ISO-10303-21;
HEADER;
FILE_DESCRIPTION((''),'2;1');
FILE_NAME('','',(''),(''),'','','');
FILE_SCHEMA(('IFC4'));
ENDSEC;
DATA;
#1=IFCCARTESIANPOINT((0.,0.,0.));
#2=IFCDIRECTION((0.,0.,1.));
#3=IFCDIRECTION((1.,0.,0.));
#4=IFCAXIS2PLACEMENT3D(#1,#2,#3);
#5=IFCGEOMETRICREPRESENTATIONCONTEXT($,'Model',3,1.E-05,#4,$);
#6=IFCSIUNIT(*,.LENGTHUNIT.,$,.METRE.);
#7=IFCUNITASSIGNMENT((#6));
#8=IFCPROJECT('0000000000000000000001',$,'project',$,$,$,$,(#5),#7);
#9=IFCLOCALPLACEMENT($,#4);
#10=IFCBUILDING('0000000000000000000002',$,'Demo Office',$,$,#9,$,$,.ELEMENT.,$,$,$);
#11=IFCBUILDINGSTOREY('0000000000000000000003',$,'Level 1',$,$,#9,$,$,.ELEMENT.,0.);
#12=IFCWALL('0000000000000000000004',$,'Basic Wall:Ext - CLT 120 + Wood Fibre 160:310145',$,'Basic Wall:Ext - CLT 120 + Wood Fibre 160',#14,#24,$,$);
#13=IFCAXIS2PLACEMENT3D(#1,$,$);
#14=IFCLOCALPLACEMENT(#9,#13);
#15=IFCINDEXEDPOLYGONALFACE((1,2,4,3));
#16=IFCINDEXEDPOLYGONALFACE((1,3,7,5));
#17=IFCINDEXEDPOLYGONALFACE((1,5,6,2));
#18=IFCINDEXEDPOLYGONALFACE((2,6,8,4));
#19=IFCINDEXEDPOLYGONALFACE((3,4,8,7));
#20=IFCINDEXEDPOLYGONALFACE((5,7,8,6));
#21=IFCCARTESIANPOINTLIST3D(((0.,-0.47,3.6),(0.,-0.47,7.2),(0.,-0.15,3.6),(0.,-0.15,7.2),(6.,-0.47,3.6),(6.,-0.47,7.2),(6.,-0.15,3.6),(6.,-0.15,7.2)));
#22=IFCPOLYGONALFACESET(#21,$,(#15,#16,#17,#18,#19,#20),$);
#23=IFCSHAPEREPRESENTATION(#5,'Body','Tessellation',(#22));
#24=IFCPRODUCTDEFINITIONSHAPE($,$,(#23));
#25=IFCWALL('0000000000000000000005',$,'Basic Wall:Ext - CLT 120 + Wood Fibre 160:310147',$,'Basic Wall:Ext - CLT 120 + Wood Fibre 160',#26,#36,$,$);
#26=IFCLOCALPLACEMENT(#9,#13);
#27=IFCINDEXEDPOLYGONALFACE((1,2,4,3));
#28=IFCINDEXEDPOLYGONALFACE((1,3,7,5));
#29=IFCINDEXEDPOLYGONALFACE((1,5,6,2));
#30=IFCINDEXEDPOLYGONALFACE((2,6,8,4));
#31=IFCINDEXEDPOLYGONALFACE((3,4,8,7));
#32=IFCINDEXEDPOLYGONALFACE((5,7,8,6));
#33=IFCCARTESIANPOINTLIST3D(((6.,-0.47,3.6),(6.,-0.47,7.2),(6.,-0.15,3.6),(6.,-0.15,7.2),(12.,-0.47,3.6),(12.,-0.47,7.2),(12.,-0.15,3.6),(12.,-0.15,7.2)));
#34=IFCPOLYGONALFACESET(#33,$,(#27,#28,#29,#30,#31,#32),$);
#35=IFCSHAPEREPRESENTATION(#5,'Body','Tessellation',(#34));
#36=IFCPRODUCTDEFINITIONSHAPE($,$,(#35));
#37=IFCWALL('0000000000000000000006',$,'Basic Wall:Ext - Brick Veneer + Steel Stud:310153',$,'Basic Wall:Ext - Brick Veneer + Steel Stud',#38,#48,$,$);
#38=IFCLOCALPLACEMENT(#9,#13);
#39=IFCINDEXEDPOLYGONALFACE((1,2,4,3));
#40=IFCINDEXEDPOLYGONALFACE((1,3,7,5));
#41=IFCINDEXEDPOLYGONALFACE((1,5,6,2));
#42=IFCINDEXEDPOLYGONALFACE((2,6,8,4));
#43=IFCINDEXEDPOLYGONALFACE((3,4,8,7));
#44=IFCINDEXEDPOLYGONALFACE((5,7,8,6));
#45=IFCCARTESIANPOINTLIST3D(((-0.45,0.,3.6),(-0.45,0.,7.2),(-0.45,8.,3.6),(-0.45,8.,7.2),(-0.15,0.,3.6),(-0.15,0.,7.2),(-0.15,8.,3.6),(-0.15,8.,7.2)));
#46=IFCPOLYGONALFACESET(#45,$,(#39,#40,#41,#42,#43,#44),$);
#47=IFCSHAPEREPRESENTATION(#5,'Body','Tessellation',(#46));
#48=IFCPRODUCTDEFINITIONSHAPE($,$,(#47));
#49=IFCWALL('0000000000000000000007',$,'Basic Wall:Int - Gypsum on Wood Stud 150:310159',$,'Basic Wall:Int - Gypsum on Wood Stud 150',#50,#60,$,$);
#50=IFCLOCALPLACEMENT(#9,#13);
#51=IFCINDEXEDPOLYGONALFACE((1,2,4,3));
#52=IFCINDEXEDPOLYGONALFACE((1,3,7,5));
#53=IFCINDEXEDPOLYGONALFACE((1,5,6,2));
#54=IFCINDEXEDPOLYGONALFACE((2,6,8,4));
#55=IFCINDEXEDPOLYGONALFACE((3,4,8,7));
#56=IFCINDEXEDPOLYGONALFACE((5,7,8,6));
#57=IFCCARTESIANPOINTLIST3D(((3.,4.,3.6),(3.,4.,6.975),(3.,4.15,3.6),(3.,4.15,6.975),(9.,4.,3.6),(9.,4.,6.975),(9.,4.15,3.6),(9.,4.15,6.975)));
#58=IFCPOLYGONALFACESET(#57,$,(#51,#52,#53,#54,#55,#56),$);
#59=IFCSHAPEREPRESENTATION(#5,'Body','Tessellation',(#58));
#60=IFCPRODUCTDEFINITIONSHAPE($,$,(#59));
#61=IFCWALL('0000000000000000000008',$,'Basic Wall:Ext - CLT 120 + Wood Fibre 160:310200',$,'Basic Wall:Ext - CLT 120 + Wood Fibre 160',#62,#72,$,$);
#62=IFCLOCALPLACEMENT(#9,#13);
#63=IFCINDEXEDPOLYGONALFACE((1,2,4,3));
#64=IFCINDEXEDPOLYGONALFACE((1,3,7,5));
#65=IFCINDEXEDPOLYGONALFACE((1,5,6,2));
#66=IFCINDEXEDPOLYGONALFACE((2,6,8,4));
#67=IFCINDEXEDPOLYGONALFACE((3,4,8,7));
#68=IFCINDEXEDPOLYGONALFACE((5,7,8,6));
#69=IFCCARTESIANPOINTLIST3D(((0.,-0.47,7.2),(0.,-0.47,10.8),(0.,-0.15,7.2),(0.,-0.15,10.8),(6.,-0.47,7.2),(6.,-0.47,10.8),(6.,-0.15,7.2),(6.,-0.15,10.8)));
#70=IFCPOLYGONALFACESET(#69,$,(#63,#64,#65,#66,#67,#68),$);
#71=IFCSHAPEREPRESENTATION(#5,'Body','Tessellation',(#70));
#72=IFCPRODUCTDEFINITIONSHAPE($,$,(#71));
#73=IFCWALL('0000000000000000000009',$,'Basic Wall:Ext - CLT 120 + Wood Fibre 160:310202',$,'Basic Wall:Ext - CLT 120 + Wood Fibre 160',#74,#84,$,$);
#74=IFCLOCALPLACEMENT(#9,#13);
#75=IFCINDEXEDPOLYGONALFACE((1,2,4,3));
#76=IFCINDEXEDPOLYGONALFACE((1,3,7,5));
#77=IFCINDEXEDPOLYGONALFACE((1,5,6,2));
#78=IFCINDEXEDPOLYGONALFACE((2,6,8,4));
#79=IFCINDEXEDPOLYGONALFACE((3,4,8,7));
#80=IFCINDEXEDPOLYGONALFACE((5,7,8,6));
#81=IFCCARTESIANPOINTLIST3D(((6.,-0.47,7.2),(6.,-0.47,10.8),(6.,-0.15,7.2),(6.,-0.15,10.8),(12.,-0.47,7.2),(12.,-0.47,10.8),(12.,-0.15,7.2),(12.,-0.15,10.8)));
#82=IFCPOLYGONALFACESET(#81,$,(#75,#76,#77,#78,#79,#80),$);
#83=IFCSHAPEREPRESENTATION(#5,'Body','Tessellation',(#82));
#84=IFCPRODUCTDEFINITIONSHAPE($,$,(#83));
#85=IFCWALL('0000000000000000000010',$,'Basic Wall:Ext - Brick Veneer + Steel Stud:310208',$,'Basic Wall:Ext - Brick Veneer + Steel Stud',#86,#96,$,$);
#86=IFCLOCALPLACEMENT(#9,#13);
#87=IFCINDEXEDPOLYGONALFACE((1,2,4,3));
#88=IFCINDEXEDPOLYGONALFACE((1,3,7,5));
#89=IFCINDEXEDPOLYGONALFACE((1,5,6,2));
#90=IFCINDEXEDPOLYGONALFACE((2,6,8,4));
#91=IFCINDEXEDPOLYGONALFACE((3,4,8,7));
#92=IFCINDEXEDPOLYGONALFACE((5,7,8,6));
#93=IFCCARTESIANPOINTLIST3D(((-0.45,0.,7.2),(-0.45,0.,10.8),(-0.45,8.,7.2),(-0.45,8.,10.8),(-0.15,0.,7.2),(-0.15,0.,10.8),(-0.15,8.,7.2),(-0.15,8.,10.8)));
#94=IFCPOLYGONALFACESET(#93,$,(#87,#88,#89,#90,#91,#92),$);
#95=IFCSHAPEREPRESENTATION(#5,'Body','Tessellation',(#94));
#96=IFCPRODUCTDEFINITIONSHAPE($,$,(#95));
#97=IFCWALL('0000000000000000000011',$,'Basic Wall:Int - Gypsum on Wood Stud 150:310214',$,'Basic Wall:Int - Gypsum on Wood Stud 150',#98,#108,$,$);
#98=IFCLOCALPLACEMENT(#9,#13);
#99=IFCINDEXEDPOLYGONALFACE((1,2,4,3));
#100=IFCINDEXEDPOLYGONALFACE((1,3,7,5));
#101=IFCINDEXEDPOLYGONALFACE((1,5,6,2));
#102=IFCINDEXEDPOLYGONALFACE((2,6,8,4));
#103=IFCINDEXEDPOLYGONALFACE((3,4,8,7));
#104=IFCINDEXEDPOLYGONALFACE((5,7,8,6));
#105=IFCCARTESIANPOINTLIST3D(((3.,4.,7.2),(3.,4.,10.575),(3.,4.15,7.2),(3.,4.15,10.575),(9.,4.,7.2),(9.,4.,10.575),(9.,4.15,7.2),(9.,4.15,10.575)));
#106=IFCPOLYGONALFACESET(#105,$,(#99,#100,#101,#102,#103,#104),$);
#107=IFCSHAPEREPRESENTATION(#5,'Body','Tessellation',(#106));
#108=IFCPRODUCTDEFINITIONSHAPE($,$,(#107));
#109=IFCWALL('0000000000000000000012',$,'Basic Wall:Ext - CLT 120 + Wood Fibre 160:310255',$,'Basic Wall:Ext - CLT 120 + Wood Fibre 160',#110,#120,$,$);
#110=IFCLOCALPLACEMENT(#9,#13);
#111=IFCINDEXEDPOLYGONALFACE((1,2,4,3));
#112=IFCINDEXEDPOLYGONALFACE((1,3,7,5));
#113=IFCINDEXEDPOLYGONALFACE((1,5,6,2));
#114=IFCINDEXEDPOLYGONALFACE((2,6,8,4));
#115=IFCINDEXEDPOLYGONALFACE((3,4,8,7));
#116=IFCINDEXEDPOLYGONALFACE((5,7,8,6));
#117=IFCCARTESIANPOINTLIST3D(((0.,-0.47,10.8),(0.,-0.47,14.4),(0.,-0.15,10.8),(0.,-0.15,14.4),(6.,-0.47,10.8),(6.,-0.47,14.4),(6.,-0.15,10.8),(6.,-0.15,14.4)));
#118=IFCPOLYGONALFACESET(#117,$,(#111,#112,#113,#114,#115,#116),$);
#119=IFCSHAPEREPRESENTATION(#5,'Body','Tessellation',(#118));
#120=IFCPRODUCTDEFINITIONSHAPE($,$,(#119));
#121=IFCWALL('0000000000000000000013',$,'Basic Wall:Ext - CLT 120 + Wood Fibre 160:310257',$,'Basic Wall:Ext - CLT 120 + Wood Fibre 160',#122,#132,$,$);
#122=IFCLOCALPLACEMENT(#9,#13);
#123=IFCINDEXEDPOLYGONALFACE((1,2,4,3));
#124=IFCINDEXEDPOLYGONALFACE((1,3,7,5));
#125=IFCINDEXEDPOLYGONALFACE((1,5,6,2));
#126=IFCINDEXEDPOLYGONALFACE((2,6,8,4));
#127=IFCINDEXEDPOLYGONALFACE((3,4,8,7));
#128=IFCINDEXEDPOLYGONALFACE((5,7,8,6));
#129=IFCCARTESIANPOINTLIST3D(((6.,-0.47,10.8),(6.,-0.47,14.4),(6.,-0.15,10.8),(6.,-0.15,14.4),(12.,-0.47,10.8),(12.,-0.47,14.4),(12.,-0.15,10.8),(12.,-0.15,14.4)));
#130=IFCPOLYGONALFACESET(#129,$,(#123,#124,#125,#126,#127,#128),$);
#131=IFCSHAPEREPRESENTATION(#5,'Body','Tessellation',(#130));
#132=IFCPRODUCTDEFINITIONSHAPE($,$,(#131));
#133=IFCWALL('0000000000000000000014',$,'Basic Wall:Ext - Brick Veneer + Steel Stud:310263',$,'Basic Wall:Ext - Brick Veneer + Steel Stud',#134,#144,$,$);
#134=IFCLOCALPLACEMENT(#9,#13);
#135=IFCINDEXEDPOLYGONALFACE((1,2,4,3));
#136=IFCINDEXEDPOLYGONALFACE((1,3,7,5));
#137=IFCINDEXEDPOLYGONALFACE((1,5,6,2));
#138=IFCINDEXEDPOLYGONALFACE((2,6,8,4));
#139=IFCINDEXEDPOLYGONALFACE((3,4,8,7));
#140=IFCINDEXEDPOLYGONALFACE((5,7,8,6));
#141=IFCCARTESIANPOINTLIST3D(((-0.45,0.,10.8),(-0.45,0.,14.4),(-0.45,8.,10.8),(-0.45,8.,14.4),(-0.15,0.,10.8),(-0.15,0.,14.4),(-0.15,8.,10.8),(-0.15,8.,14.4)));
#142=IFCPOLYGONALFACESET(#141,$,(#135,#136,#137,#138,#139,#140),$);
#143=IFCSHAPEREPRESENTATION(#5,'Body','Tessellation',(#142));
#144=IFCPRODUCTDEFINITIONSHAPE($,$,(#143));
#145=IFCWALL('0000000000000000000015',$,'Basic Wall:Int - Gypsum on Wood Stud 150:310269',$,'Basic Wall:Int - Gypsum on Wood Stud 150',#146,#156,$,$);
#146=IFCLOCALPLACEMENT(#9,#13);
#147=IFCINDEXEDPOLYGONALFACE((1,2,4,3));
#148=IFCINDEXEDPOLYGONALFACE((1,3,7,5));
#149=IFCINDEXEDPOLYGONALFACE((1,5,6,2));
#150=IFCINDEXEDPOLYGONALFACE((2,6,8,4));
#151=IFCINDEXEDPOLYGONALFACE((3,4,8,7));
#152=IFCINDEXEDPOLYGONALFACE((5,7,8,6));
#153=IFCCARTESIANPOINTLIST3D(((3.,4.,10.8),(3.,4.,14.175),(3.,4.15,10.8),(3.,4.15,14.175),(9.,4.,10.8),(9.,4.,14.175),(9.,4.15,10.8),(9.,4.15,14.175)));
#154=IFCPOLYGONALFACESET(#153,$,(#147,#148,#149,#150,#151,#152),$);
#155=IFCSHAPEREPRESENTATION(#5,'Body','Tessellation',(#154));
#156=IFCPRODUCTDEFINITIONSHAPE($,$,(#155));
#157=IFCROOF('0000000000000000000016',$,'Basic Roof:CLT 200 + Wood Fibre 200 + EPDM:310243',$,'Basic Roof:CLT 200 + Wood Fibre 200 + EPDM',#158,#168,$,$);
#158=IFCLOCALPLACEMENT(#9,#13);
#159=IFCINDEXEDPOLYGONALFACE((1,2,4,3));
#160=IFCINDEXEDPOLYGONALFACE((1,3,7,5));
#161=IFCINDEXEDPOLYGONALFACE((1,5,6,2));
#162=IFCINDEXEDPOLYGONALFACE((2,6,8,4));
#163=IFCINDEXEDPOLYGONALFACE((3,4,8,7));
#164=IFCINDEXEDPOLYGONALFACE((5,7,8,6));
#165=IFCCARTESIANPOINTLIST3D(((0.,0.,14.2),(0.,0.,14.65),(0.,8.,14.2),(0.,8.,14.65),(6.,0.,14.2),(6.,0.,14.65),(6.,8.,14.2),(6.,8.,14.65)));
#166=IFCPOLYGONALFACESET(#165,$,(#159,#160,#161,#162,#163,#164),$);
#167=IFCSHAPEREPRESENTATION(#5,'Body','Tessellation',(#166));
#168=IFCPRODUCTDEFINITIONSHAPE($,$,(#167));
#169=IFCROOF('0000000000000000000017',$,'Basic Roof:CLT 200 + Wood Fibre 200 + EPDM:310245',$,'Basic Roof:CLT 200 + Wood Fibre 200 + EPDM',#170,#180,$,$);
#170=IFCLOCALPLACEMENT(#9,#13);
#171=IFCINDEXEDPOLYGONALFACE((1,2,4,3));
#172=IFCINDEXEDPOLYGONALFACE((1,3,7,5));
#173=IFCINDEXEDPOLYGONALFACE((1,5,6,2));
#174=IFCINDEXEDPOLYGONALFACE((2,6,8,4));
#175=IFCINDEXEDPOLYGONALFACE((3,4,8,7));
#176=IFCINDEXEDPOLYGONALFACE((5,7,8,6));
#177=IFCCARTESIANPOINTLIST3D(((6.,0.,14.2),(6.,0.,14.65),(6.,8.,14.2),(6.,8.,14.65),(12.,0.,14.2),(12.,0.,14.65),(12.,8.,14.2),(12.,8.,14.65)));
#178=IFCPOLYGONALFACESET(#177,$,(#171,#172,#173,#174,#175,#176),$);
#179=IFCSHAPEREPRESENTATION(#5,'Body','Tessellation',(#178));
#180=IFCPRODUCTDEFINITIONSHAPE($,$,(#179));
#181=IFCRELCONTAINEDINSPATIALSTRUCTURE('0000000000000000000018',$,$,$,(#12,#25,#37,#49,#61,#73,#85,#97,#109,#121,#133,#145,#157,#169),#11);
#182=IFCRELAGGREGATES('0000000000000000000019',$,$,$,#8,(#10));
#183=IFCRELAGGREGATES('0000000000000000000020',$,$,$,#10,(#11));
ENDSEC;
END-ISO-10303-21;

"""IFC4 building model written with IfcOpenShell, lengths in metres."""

from ifc_helpers import new_model, si_unit, frame, origin_with_axes, origin_2d, place, context, project, spatial, rectangle, extrude, element, save


model = new_model("IFC4")

# Units and contexts
model_context = context("Model", 3, precision=1e-05, world=origin_with_axes())
ifc_project = project(units=[si_unit("LENGTHUNIT", "METRE")], contexts=[model_context])

# Building, storey
placement = place(None, origin_with_axes())
building = spatial("IfcBuilding", under=ifc_project, at=placement, Name="Demo Office", CompositionType="ELEMENT")
storey = spatial("IfcBuildingStorey", under=building, at=placement, Name="Level 1", CompositionType="ELEMENT", Elevation=0.0)

# Walls
for number, where, name in (
    (1, (3.0, -0.31, 3.6), "Basic Wall:Ext - CLT 120 + Wood Fibre 160:310145"),
    (2, (9.0, -0.31, 3.6), "Basic Wall:Ext - CLT 120 + Wood Fibre 160:310147"),
):
    element("IfcWall", number, at=place(placement, frame(where)), inside=storey, Name=name, ObjectType="Basic Wall:Ext - CLT 120 + Wood Fibre 160", context=model_context, shape_type="SweptSolid", body=[
        extrude(rectangle(XDim=6.0, YDim=0.32, at=origin_2d()), origin_with_axes(), (0.0, 0.0, 1.0), 3.6),
    ])
wall_1_placement = place(placement, frame((-0.3, 4.0, 3.6)))
element("IfcWall", 3, at=wall_1_placement, inside=storey, Name="Basic Wall:Ext - Brick Veneer + Steel Stud:310153", ObjectType="Basic Wall:Ext - Brick Veneer + Steel Stud", context=model_context, shape_type="SweptSolid", body=[
    extrude(rectangle(XDim=0.3, YDim=8.0, at=origin_2d()), origin_with_axes(), (0.0, 0.0, 1.0), 3.6),
])
wall_2_placement = place(placement, frame((6.0, 4.075, 3.6)))
element("IfcWall", 4, at=wall_2_placement, inside=storey, Name="Basic Wall:Int - Gypsum on Wood Stud 150:310159", ObjectType="Basic Wall:Int - Gypsum on Wood Stud 150", context=model_context, shape_type="SweptSolid", body=[
    extrude(rectangle(XDim=6.0, YDim=0.15, at=origin_2d()), origin_with_axes(), (0.0, 0.0, 1.0), 3.375),
])
for number, where, name in (
    (5, (3.0, -0.31, 7.2), "Basic Wall:Ext - CLT 120 + Wood Fibre 160:310200"),
    (6, (9.0, -0.31, 7.2), "Basic Wall:Ext - CLT 120 + Wood Fibre 160:310202"),
):
    element("IfcWall", number, at=place(placement, frame(where)), inside=storey, Name=name, ObjectType="Basic Wall:Ext - CLT 120 + Wood Fibre 160", context=model_context, shape_type="SweptSolid", body=[
        extrude(rectangle(XDim=6.0, YDim=0.32, at=origin_2d()), origin_with_axes(), (0.0, 0.0, 1.0), 3.6),
    ])
wall_3_placement = place(placement, frame((-0.3, 4.0, 7.2)))
element("IfcWall", 7, at=wall_3_placement, inside=storey, Name="Basic Wall:Ext - Brick Veneer + Steel Stud:310208", ObjectType="Basic Wall:Ext - Brick Veneer + Steel Stud", context=model_context, shape_type="SweptSolid", body=[
    extrude(rectangle(XDim=0.3, YDim=8.0, at=origin_2d()), origin_with_axes(), (0.0, 0.0, 1.0), 3.6),
])
wall_4_placement = place(placement, frame((6.0, 4.075, 7.2)))
element("IfcWall", 8, at=wall_4_placement, inside=storey, Name="Basic Wall:Int - Gypsum on Wood Stud 150:310214", ObjectType="Basic Wall:Int - Gypsum on Wood Stud 150", context=model_context, shape_type="SweptSolid", body=[
    extrude(rectangle(XDim=6.0, YDim=0.15, at=origin_2d()), origin_with_axes(), (0.0, 0.0, 1.0), 3.375),
])
for number, where, name in (
    (9, (3.0, -0.31, 10.8), "Basic Wall:Ext - CLT 120 + Wood Fibre 160:310255"),
    (10, (9.0, -0.31, 10.8), "Basic Wall:Ext - CLT 120 + Wood Fibre 160:310257"),
):
    element("IfcWall", number, at=place(placement, frame(where)), inside=storey, Name=name, ObjectType="Basic Wall:Ext - CLT 120 + Wood Fibre 160", context=model_context, shape_type="SweptSolid", body=[
        extrude(rectangle(XDim=6.0, YDim=0.32, at=origin_2d()), origin_with_axes(), (0.0, 0.0, 1.0), 3.6),
    ])
wall_5_placement = place(placement, frame((-0.3, 4.0, 10.8)))
element("IfcWall", 11, at=wall_5_placement, inside=storey, Name="Basic Wall:Ext - Brick Veneer + Steel Stud:310263", ObjectType="Basic Wall:Ext - Brick Veneer + Steel Stud", context=model_context, shape_type="SweptSolid", body=[
    extrude(rectangle(XDim=0.3, YDim=8.0, at=origin_2d()), origin_with_axes(), (0.0, 0.0, 1.0), 3.6),
])
wall_6_placement = place(placement, frame((6.0, 4.075, 10.8)))
element("IfcWall", 12, at=wall_6_placement, inside=storey, Name="Basic Wall:Int - Gypsum on Wood Stud 150:310269", ObjectType="Basic Wall:Int - Gypsum on Wood Stud 150", context=model_context, shape_type="SweptSolid", body=[
    extrude(rectangle(XDim=6.0, YDim=0.15, at=origin_2d()), origin_with_axes(), (0.0, 0.0, 1.0), 3.375),
])

# Roofs
for number, where, name in (
    (13, (3.0, 4.0, 14.2), "Basic Roof:CLT 200 + Wood Fibre 200 + EPDM:310243"),
    (14, (9.0, 4.0, 14.2), "Basic Roof:CLT 200 + Wood Fibre 200 + EPDM:310245"),
):
    element("IfcRoof", number, at=place(placement, frame(where)), inside=storey, Name=name, ObjectType="Basic Roof:CLT 200 + Wood Fibre 200 + EPDM", context=model_context, shape_type="SweptSolid", body=[
        extrude(rectangle(XDim=6.0, YDim=8.0, at=origin_2d()), origin_with_axes(), (0.0, 0.0, 1.0), 0.45),
    ])

save(model, "model.ifc")
